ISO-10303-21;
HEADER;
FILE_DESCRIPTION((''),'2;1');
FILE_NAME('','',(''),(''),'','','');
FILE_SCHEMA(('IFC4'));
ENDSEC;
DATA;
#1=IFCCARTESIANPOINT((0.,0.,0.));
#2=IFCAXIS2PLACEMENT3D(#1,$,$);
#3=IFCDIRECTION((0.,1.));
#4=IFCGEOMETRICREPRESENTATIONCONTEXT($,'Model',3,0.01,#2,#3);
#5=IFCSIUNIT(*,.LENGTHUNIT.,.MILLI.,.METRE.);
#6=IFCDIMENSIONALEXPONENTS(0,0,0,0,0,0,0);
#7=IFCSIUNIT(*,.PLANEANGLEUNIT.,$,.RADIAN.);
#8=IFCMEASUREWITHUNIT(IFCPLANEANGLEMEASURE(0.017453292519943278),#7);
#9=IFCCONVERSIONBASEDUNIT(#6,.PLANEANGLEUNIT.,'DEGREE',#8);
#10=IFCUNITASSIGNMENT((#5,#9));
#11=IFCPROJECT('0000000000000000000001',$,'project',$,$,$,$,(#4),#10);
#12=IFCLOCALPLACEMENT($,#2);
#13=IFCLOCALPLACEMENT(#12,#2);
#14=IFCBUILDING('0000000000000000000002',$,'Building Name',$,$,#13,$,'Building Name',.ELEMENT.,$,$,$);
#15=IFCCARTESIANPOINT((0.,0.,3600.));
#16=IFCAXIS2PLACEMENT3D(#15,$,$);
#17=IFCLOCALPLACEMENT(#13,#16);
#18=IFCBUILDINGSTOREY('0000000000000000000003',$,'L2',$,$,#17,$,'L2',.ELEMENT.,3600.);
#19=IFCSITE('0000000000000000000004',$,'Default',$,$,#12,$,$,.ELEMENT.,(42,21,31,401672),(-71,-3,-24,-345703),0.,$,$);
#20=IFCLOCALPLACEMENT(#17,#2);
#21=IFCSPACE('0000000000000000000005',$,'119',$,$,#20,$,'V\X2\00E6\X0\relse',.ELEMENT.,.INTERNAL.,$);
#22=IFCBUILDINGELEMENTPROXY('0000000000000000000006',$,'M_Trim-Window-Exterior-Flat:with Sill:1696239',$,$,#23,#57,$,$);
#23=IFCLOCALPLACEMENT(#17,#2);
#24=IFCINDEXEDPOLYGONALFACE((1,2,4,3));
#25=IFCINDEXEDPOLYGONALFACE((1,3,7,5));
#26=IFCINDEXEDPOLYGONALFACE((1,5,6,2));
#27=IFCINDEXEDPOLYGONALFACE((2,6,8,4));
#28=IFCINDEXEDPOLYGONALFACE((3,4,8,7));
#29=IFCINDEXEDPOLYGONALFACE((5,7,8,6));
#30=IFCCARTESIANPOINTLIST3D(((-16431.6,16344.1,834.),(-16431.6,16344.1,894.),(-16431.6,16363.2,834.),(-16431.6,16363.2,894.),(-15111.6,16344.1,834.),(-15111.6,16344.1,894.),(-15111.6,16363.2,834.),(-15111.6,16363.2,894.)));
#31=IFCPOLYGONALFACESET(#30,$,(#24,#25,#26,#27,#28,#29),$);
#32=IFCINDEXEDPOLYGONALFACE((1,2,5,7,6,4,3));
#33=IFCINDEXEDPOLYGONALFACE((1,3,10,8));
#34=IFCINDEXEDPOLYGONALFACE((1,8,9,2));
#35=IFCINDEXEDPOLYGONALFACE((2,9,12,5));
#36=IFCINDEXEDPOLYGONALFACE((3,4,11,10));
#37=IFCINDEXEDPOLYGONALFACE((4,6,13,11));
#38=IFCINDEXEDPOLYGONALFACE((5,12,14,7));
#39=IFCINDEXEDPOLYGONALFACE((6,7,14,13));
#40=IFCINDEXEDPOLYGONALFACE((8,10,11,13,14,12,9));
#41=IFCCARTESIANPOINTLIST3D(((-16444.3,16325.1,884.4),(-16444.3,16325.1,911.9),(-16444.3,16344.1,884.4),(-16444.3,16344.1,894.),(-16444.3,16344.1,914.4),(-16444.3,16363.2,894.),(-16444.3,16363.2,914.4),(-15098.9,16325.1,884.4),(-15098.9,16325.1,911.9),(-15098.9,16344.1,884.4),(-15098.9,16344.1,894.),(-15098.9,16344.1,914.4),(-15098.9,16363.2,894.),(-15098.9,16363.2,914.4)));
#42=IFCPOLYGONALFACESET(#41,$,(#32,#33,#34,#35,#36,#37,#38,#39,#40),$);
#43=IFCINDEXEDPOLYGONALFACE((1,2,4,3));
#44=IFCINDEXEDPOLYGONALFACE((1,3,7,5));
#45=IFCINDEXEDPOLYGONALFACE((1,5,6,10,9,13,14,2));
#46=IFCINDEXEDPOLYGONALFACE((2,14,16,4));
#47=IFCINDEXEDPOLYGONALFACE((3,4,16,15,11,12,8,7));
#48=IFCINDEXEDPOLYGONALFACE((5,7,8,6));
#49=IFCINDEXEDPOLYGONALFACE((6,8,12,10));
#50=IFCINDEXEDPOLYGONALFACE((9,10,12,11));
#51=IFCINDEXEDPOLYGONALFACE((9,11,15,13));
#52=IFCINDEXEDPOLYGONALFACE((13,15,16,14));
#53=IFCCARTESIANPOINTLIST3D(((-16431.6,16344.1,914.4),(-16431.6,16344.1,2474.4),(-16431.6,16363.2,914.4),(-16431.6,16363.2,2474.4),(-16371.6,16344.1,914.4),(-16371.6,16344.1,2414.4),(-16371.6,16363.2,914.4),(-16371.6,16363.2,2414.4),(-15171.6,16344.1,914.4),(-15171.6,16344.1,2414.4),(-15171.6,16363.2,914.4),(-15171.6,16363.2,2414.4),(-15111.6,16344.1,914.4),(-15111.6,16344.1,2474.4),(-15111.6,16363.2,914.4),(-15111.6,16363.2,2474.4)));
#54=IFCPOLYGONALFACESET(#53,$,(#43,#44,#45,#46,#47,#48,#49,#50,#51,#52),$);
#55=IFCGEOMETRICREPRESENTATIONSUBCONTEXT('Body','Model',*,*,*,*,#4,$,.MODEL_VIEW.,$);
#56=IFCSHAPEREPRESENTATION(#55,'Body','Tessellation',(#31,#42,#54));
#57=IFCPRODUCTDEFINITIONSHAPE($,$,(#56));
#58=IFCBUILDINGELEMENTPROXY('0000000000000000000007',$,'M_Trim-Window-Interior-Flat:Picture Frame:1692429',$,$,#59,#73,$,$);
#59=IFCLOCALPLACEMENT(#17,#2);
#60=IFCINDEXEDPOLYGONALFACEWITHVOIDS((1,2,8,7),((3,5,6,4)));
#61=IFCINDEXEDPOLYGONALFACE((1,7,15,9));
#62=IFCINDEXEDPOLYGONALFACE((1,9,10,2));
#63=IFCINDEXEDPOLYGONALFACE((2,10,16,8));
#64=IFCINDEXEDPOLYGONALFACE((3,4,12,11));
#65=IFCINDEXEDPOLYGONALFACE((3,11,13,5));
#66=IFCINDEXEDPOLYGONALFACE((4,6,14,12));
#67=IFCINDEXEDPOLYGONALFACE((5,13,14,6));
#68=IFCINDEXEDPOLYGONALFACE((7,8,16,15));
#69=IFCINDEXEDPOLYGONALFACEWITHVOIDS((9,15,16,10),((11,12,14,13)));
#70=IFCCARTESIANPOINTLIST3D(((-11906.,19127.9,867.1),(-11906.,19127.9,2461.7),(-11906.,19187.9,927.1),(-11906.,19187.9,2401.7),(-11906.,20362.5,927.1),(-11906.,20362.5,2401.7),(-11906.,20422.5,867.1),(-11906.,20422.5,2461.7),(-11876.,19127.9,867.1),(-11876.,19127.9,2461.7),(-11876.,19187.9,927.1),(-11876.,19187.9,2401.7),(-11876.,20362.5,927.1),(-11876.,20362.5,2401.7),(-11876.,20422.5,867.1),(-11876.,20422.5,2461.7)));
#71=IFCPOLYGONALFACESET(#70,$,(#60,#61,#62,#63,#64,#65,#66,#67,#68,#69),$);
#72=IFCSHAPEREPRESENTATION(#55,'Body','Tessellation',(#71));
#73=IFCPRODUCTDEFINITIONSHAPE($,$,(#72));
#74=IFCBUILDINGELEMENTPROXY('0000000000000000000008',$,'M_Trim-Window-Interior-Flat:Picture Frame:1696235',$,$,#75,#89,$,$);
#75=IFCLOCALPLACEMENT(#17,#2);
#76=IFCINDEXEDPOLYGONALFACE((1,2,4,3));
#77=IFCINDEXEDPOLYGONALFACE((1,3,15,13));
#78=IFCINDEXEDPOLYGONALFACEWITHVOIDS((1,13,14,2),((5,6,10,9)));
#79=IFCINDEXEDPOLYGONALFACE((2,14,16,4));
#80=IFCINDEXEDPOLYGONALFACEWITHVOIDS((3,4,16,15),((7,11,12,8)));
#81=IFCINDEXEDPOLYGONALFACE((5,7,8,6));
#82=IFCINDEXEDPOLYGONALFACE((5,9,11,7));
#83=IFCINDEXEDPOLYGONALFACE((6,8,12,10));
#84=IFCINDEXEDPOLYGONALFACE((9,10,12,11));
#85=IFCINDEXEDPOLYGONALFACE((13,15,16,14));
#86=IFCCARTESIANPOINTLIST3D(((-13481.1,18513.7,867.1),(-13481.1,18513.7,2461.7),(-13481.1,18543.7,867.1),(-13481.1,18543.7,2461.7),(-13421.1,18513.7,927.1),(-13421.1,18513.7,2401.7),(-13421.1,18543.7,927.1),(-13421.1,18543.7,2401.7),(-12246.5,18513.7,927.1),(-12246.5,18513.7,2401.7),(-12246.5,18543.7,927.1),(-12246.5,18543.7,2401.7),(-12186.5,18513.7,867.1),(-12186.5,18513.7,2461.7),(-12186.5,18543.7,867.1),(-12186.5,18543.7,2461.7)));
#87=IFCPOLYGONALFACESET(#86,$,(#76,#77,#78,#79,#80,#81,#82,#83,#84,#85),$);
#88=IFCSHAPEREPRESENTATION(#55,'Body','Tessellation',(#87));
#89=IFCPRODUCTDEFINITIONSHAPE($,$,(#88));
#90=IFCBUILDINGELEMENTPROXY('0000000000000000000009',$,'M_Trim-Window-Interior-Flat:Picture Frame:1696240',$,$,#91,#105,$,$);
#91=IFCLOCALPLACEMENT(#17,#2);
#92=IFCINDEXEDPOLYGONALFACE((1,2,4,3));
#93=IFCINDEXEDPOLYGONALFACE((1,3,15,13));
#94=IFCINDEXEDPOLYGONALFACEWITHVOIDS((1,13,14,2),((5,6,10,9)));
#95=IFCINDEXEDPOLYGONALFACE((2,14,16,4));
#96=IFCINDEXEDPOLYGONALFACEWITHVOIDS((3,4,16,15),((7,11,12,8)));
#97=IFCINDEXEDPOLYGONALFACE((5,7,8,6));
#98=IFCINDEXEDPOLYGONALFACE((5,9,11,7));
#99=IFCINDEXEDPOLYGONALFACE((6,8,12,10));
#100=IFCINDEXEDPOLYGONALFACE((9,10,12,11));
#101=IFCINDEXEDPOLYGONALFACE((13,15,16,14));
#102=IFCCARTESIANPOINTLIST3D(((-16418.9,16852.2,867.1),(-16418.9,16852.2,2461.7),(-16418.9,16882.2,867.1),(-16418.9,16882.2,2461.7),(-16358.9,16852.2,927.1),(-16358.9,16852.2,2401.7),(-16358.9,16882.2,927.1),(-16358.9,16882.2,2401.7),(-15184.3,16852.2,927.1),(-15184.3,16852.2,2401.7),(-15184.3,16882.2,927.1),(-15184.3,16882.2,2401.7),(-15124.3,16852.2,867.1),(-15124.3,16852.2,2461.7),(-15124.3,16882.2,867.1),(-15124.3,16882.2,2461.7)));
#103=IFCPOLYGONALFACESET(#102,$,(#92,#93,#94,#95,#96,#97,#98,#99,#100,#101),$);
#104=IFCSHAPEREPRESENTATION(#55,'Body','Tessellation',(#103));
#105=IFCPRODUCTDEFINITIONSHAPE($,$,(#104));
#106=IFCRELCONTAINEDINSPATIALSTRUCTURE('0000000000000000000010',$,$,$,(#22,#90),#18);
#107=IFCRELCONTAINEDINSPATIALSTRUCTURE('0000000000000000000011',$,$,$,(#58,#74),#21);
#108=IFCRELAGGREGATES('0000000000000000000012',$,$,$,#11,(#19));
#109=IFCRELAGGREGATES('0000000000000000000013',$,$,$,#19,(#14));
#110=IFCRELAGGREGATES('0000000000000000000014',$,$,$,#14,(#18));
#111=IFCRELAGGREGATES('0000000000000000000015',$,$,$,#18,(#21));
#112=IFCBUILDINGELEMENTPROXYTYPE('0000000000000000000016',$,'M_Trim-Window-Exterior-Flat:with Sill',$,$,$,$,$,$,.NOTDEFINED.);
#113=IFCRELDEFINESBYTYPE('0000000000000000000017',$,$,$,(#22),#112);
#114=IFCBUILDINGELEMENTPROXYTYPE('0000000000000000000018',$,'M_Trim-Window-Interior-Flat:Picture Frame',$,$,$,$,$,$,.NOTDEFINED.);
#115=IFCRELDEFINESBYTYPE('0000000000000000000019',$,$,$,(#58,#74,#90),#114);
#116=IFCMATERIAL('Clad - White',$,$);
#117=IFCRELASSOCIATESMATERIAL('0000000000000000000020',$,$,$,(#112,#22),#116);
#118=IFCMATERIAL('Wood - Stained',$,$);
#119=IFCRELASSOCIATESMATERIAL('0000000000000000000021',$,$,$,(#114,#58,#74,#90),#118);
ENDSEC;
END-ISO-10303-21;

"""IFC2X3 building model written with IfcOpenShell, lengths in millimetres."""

from ifc_helpers import new_model, entity, si_unit, converted_unit, direction, frame, frame_2d, origin, place, context, subcontext, project, spatial, polyline, rectangle, outline, extrude, source, transform, mapped, material, type_object, type_shapes, element, save


model = new_model("IFC2X3")

# Units and contexts
model_context = context("Model", 3, precision=0.01, world=origin(), true_north=direction((0.0, 1.0)))
body_context = subcontext(model_context, "Body", "Model", "MODEL_VIEW")
ifc_project = project(units=[si_unit("LENGTHUNIT", "METRE", prefix="MILLI"), converted_unit("PLANEANGLEUNIT", "DEGREE", entity("IfcPlaneAngleMeasure", 0.017453292519943278), si_unit("PLANEANGLEUNIT", "RADIAN"), dimensions=[0, 0, 0, 0, 0, 0, 0])], contexts=[model_context])

# Site, building, storey
site_placement = place(None, origin())
site = spatial("IfcSite", under=ifc_project, at=site_placement, Name="Default", CompositionType="ELEMENT", RefLatitude=(42, 21, 31, 401672), RefLongitude=(-71, -3, -24, -345703), RefElevation=0.0)
building_placement = place(site_placement, origin())
building = spatial("IfcBuilding", under=site, at=building_placement, Name="Building Name", LongName="Building Name", CompositionType="ELEMENT")
storey_placement = place(building_placement, frame((0.0, 0.0, 3600.0)))
storey = spatial("IfcBuildingStorey", under=building, at=storey_placement, Name="L2", LongName="L2", CompositionType="ELEMENT", Elevation=3600.0)

# Shared definitions
ifc_material_1 = material(Name="Wood - Stained")

# Building element proxy
ifc_material_2 = material(Name="Clad - White")
building_element_proxy_type_1 = type_object("IfcBuildingElementProxyType", Name="M_Trim-Window-Exterior-Flat:with Sill", PredefinedType="NOTDEFINED", material=ifc_material_2)
shared_shape_1 = source(origin(), body_context, "Body", "SweptSolid", [
    extrude(rectangle(XDim=1320.0, YDim=60.0, at=frame_2d((0.0, 0.0), x_axis=(1.0, 0.0))), frame((0.0, -1550.4, 0.0), z_axis=(0.0, 0.0, 1.0), x_axis=(-1.0, 0.0, 0.0)), (0.0, 0.0, 1.0), 19.0),
    extrude(outline(polyline([(-19.0, -15.2), (0.0, -15.2), (0.0, -5.7), (19.0, -5.7), (19.0, 14.8), (0.0, 14.8), (-19.0, 12.3), (-19.0, -15.2)])), frame((-672.7, -1514.8, 19.0), z_axis=(1.0, 0.0, 0.0), x_axis=(0.0, 0.0, -1.0)), (0.0, 0.0, 1.0), 1345.4),
    extrude(outline(polyline([(-795.0, -660.0), (765.0, -660.0), (765.0, -600.0), (-735.0, -600.0), (-735.0, 600.0), (765.0, 600.0), (765.0, 660.0), (-795.0, 660.0), (-795.0, -660.0)])), frame((0.0, -735.0, 0.0), z_axis=(0.0, 0.0, 1.0), x_axis=(0.0, -1.0, 0.0)), (0.0, 0.0, 1.0), 19.0),
])
type_shapes(building_element_proxy_type_1, [shared_shape_1])
for number, where, z_axis, x_axis, name in (
    (1, (-15771.6, 16363.2, 2414.4), (0.0, -1.0, 0.0), (1.0, 0.0, 0.0), "M_Trim-Window-Exterior-Flat:with Sill:1696239"),
):
    element("IfcBuildingElementProxy", number, at=place(storey_placement, frame(where, z_axis=z_axis, x_axis=x_axis)), inside=storey, type_object=building_element_proxy_type_1, material=ifc_material_2, Name=name, context=body_context, shape_type="MappedRepresentation", body=[
        mapped(shared_shape_1, transform((0.0, 0.0, 0.0), scale=1.0)),
    ])

# Shared definitions
space_placement = place(storey_placement, origin())
space = spatial("IfcSpace", under=storey, at=space_placement, Name="119", LongName="Værelse", CompositionType="ELEMENT", InteriorOrExteriorSpace="INTERNAL")

# Building element proxies
building_element_proxy_type_2 = type_object("IfcBuildingElementProxyType", Name="M_Trim-Window-Interior-Flat:Picture Frame", PredefinedType="NOTDEFINED", material=ifc_material_1)
shared_shape_2 = source(origin(), body_context, "Body", "SweptSolid", [
    extrude(outline(polyline([(-647.3, -797.3), (647.3, -797.3), (647.3, 797.3), (-647.3, 797.3), (-647.3, -797.3)]), holes=[polyline([(-587.3, -737.3), (-587.3, 737.3), (587.3, 737.3), (587.3, -737.3), (-587.3, -737.3)])]), frame((0.0, -750.0, 0.0), z_axis=(0.0, 0.0, 1.0), x_axis=(-1.0, 0.0, 0.0)), (0.0, 0.0, 1.0), 30.0),
])
type_shapes(building_element_proxy_type_2, [shared_shape_2])
for number, where, z_axis, x_axis, name in (
    (2, (-11876.0, 19775.2, 2414.4), (-1.0, 0.0, 0.0), (0.0, -1.0, 0.0), "M_Trim-Window-Interior-Flat:Picture Frame:1692429"),
    (3, (-12833.8, 18513.7, 2414.4), (0.0, 1.0, 0.0), (-1.0, 0.0, 0.0), "M_Trim-Window-Interior-Flat:Picture Frame:1696235"),
):
    element("IfcBuildingElementProxy", number, at=place(space_placement, frame(where, z_axis=z_axis, x_axis=x_axis)), inside=space, type_object=building_element_proxy_type_2, material=ifc_material_1, Name=name, context=body_context, shape_type="MappedRepresentation", body=[
        mapped(shared_shape_2, transform((0.0, 0.0, 0.0), scale=1.0)),
    ])
proxy_placement = place(storey_placement, frame((-15771.6, 16852.2, 2414.4), z_axis=(0.0, 1.0, 0.0), x_axis=(-1.0, 0.0, 0.0)))
element("IfcBuildingElementProxy", 4, at=proxy_placement, inside=storey, type_object=building_element_proxy_type_2, material=ifc_material_1, Name="M_Trim-Window-Interior-Flat:Picture Frame:1696240", context=body_context, shape_type="MappedRepresentation", body=[
    mapped(shared_shape_2, transform((0.0, 0.0, 0.0), scale=1.0)),
])

save(model, "model.ifc")
